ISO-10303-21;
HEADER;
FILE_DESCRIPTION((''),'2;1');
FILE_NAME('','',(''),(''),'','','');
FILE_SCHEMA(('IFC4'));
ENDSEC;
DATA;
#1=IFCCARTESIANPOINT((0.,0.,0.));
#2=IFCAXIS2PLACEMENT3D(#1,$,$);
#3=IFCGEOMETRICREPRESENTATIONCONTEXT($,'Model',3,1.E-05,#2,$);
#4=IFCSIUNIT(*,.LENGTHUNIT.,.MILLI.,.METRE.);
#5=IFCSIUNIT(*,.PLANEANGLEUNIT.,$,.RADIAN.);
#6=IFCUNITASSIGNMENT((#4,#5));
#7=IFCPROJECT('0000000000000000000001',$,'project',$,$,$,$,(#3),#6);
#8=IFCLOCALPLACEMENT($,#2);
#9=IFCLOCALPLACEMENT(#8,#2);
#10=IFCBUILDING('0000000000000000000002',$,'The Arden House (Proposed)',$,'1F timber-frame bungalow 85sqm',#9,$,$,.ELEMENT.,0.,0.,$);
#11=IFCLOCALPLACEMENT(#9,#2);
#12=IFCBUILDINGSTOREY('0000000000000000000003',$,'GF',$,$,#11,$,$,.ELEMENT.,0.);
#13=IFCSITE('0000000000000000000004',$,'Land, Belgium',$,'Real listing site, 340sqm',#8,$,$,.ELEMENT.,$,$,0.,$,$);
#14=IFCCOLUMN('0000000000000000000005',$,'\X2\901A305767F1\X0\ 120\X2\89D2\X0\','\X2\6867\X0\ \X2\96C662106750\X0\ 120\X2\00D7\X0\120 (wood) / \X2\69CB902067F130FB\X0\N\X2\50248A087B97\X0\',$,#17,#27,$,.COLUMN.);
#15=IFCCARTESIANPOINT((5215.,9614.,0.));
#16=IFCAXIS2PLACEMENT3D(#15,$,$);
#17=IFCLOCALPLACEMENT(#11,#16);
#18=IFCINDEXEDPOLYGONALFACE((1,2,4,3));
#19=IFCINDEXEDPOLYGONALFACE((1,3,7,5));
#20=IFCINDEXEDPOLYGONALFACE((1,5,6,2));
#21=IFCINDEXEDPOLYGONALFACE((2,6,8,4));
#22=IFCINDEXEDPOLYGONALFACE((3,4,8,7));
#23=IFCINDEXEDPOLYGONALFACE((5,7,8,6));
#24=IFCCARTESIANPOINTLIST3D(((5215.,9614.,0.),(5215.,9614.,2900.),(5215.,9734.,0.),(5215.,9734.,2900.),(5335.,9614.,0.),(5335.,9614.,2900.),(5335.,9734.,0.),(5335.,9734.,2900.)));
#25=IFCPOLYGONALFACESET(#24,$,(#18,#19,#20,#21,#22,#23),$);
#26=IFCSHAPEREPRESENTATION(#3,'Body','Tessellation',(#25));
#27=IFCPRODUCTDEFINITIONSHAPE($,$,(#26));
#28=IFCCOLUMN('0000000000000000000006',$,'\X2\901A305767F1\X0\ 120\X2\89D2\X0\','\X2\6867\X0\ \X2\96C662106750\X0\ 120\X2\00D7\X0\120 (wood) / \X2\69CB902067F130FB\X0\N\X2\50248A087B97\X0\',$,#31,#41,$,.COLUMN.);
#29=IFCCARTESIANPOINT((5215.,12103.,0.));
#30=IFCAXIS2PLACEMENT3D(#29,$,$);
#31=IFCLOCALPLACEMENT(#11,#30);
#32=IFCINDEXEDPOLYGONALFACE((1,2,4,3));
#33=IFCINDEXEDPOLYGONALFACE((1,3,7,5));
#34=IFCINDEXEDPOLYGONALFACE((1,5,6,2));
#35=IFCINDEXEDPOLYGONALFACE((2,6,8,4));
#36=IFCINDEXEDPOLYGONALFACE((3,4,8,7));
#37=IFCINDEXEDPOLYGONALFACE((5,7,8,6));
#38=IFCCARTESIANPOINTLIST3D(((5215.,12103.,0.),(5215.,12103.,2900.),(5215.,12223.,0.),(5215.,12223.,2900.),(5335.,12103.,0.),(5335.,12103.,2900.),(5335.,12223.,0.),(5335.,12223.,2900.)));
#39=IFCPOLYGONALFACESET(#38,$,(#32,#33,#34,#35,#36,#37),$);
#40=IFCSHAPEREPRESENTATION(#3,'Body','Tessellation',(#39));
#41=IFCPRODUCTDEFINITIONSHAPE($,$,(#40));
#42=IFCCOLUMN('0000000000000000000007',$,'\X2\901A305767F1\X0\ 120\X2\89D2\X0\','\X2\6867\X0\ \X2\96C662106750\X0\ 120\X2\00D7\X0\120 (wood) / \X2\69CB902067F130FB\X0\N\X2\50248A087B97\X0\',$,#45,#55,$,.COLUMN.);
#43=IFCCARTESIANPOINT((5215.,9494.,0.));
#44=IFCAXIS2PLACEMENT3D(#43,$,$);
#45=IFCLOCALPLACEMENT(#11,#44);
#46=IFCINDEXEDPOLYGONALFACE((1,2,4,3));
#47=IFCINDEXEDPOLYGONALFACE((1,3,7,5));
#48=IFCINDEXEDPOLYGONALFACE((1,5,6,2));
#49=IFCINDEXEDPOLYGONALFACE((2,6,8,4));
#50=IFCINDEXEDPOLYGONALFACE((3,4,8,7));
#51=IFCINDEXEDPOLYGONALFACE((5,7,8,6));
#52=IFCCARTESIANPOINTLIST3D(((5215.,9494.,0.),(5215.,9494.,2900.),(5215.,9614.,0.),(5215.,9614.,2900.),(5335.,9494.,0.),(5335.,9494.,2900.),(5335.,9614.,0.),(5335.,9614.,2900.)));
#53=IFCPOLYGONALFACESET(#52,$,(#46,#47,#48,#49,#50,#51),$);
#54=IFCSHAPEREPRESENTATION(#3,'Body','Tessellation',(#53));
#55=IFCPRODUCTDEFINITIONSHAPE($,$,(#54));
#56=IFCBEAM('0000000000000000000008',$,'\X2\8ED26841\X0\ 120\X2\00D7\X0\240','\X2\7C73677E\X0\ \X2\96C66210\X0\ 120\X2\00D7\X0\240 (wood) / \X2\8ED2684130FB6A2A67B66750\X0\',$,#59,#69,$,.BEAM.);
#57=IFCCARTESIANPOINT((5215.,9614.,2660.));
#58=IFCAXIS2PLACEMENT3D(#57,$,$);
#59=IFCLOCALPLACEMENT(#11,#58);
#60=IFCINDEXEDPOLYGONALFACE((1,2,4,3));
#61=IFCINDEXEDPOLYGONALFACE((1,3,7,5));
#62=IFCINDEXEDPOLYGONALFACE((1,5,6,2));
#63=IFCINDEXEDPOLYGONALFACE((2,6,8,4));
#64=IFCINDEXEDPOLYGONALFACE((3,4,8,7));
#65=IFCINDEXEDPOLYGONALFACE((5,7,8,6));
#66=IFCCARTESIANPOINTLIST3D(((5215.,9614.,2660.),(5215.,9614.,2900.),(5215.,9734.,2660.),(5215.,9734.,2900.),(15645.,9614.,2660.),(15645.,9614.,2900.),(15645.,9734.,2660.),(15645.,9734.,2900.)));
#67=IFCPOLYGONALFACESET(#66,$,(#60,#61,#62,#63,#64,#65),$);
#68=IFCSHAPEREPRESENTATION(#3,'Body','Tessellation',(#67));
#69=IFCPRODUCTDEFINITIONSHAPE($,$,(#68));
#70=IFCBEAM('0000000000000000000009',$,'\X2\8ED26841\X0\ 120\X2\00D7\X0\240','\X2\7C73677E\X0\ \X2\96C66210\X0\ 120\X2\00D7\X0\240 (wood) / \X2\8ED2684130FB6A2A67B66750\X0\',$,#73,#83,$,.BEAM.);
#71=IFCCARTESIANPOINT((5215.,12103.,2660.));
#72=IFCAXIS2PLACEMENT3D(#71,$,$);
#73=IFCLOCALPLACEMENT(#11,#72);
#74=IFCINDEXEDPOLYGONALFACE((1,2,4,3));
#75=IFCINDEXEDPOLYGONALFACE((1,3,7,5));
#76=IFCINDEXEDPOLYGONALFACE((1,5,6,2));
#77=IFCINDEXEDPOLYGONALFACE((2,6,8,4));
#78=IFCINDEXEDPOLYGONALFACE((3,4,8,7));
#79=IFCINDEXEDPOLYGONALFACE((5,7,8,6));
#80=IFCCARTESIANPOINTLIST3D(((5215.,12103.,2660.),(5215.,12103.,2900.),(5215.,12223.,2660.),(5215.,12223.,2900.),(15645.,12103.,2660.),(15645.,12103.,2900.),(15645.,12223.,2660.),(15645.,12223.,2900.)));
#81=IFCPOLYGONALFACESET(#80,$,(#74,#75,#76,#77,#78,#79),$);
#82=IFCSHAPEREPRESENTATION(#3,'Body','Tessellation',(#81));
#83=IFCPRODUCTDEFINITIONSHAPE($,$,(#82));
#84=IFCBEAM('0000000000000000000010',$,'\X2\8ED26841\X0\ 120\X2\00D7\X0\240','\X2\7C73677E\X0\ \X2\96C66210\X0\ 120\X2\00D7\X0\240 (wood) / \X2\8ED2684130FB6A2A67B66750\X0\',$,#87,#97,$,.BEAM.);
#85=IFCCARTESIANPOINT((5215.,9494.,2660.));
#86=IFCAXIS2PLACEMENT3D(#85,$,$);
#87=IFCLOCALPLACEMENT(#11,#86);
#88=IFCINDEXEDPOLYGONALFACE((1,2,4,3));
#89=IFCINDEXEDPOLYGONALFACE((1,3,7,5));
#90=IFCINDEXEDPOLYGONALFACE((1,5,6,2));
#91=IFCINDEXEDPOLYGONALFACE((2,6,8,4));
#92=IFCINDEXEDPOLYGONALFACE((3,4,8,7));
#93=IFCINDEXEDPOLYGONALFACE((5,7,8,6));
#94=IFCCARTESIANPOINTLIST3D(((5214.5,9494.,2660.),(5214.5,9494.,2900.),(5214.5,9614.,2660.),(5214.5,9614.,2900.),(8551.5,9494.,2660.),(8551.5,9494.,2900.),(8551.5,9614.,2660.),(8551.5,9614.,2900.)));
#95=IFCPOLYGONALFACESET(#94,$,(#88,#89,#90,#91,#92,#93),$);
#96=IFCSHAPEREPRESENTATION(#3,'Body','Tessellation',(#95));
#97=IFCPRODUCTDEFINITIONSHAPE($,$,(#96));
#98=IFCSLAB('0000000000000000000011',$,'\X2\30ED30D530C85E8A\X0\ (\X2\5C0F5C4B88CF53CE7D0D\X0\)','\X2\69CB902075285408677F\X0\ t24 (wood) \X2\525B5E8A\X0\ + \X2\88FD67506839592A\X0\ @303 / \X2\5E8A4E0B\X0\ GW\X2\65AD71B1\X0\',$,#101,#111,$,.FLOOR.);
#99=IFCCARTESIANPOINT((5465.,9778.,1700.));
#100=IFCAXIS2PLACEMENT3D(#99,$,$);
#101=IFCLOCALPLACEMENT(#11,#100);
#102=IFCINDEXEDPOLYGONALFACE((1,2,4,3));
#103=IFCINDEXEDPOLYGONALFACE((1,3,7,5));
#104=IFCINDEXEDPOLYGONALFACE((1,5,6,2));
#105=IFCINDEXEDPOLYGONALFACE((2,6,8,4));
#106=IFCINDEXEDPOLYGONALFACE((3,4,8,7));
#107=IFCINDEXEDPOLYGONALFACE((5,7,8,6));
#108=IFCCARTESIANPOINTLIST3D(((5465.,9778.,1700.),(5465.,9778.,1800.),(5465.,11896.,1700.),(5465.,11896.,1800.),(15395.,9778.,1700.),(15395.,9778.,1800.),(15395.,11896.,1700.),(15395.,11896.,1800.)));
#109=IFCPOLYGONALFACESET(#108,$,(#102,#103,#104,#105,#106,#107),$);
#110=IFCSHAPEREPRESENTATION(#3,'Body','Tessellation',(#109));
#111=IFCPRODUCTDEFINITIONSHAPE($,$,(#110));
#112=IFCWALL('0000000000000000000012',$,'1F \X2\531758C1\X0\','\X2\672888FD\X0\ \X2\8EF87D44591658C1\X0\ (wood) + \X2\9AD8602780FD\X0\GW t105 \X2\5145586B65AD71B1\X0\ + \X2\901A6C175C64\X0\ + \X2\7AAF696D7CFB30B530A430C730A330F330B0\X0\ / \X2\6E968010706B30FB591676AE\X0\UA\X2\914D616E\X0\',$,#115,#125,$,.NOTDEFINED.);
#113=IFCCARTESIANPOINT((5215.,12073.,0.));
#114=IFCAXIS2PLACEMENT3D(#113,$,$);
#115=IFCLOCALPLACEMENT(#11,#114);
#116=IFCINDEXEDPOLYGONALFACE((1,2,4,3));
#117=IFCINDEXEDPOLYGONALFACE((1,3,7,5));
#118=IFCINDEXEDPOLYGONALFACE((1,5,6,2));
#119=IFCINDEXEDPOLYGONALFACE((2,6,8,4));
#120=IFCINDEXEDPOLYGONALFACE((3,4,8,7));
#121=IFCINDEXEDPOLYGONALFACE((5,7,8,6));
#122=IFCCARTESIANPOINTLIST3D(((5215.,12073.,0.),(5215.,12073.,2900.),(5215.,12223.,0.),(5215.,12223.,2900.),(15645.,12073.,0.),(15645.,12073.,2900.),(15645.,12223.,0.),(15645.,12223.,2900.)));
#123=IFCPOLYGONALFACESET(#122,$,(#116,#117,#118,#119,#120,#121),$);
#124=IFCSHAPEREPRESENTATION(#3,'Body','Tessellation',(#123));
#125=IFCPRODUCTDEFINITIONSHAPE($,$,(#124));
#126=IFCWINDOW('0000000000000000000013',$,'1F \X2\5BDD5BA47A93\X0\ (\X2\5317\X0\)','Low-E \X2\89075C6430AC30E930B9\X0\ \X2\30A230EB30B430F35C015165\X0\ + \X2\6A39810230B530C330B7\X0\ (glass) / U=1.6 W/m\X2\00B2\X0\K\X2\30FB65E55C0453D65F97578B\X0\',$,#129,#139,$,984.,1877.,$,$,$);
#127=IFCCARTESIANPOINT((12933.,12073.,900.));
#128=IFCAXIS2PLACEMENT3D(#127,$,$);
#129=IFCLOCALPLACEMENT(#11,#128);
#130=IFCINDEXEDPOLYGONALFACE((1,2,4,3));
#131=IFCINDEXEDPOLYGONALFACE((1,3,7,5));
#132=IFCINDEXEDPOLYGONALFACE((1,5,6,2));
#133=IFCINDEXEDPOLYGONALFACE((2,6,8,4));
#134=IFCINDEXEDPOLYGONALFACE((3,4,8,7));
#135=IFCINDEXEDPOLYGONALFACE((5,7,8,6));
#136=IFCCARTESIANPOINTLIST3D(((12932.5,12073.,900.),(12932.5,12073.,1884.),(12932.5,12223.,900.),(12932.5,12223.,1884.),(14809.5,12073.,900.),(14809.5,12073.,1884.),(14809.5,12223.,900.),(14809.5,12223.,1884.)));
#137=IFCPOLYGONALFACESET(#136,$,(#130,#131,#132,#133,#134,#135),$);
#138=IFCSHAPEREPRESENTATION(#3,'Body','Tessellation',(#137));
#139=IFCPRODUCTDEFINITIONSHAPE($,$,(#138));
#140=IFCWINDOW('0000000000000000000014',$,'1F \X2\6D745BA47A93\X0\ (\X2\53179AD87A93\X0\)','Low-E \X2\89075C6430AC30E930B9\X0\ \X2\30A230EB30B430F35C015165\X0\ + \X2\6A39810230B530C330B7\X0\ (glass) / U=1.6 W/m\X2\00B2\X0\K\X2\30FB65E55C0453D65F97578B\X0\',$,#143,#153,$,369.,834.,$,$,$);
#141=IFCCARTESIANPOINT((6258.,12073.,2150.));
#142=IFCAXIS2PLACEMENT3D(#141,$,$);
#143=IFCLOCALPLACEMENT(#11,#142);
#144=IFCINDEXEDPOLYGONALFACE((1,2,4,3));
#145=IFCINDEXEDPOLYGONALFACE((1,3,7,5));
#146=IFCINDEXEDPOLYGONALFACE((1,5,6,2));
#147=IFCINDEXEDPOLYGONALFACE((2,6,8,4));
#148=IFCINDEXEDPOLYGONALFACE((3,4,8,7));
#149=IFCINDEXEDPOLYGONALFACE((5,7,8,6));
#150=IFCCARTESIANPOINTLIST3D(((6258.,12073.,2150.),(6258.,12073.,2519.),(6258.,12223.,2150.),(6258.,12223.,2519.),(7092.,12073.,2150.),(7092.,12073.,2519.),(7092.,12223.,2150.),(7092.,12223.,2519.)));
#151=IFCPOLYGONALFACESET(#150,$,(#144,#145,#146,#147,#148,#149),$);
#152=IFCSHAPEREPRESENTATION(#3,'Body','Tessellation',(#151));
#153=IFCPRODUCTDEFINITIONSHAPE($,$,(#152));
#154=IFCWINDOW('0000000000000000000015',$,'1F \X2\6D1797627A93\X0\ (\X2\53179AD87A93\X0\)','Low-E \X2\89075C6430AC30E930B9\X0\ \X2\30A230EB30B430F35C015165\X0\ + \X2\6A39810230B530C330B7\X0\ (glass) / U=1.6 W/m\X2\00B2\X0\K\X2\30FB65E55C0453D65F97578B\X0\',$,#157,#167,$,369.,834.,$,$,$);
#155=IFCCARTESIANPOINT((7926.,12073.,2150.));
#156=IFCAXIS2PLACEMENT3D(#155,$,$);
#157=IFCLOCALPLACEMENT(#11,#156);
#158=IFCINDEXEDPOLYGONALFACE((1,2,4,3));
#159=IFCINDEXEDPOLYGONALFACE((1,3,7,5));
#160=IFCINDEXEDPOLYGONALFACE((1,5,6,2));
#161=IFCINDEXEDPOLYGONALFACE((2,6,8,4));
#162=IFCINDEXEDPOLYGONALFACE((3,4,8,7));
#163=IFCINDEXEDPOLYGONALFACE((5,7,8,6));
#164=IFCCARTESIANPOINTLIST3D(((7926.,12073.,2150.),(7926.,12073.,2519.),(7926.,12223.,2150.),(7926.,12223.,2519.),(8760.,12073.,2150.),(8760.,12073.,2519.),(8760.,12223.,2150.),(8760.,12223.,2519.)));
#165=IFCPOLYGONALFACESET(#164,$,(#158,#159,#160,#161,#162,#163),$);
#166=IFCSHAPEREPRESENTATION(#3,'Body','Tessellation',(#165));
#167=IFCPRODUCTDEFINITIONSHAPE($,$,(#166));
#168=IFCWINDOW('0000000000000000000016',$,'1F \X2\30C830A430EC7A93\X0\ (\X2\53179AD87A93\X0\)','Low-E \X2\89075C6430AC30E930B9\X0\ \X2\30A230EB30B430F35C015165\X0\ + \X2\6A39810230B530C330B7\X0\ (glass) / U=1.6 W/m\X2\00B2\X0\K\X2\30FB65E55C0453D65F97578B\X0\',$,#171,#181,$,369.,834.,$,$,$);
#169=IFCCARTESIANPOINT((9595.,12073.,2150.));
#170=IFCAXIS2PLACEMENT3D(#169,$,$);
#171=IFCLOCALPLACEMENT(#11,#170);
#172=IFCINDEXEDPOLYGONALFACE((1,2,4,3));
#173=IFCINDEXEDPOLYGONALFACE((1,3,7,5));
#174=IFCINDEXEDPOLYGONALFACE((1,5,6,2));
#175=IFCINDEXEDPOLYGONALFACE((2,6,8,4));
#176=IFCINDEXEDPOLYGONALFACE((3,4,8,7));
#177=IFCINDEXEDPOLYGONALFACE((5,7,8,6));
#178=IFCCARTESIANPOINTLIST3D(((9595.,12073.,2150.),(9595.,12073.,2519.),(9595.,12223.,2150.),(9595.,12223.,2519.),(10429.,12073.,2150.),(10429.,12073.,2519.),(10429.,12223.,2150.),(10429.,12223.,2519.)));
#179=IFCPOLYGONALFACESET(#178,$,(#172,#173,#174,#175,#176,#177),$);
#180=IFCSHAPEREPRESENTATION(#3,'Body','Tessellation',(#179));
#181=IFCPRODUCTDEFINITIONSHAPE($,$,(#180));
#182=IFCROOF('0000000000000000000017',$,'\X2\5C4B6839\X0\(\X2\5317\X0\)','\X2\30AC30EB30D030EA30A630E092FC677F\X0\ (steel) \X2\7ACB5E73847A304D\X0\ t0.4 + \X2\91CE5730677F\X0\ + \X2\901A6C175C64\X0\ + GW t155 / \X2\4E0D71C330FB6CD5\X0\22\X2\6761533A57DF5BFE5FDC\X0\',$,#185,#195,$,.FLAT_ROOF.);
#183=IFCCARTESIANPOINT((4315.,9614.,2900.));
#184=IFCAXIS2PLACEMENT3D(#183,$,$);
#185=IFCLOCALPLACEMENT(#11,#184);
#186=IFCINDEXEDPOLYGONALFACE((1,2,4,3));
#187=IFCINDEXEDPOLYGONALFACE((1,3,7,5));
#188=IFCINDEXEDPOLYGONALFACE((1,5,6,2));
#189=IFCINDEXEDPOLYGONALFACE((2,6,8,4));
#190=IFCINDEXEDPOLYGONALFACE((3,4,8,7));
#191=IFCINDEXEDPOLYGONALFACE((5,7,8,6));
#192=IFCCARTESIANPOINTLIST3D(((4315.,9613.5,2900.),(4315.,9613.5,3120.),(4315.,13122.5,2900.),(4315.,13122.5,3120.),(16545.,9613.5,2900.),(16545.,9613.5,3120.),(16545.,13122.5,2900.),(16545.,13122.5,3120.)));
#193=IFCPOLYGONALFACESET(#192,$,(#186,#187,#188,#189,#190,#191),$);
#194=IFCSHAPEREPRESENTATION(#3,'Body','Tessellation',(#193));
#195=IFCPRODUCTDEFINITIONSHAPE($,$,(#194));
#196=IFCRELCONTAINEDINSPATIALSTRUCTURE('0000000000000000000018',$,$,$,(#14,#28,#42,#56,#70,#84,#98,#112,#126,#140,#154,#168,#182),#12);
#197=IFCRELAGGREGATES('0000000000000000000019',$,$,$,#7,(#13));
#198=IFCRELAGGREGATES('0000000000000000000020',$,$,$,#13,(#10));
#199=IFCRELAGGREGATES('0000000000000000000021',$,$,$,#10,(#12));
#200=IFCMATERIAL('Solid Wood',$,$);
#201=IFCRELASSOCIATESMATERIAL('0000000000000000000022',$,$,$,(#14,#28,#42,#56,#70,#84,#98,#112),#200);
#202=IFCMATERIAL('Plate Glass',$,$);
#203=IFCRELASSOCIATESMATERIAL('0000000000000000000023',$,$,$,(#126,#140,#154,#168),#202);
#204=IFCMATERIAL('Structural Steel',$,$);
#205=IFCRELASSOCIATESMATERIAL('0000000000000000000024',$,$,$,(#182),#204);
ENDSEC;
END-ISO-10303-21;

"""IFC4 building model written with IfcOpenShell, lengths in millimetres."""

from ifc_helpers import new_model, si_unit, frame, frame_2d, origin, place, context, project, spatial, rectangle, extrude, material, element, fill, save


model = new_model("IFC4")

# Units and contexts
model_context = context("Model", 3, precision=1e-05, world=origin())
ifc_project = project(units=[si_unit("LENGTHUNIT", "METRE", prefix="MILLI"), si_unit("PLANEANGLEUNIT", "RADIAN")], contexts=[model_context])

# Site, building, storey
site_placement = place(None, origin())
site = spatial("IfcSite", under=ifc_project, at=site_placement, Name="Land, Belgium", ObjectType="Real listing site, 340sqm", CompositionType="ELEMENT", RefElevation=0.0)
building_placement = place(site_placement, origin())
building = spatial("IfcBuilding", under=site, at=building_placement, Name="The Arden House (Proposed)", ObjectType="1F timber-frame bungalow 85sqm", CompositionType="ELEMENT", ElevationOfRefHeight=0.0, ElevationOfTerrain=0.0)
storey_placement = place(building_placement, origin())
storey = spatial("IfcBuildingStorey", under=building, at=storey_placement, Name="GF", CompositionType="ELEMENT", Elevation=0.0)

# Columns
ifc_material_1 = material(Name="Solid Wood")
column_1_placement = place(storey_placement, frame((5215.0, 9614.0, 0.0)))
element("IfcColumn", 1, at=column_1_placement, inside=storey, material=ifc_material_1, Name="通し柱 120角", Description="桧 集成材 120×120 (wood) / 構造柱・N値計算", PredefinedType="COLUMN", context=model_context, shape_type="SweptSolid", body=[
    extrude(rectangle(XDim=120.0, YDim=120.0, at=frame_2d((60.0, 60.0))), frame((5215.0, 9614.0, 0.0)), (0.0, 0.0, 1.0), 2900.0),
])
column_2_placement = place(storey_placement, frame((5215.0, 12103.0, 0.0)))
element("IfcColumn", 2, at=column_2_placement, inside=storey, material=ifc_material_1, Name="通し柱 120角", Description="桧 集成材 120×120 (wood) / 構造柱・N値計算", PredefinedType="COLUMN", context=model_context, shape_type="SweptSolid", body=[
    extrude(rectangle(XDim=120.0, YDim=120.0, at=frame_2d((60.0, 60.0))), frame((5215.0, 12103.0, 0.0)), (0.0, 0.0, 1.0), 2900.0),
])
column_3_placement = place(storey_placement, frame((5215.0, 9494.0, 0.0)))
element("IfcColumn", 3, at=column_3_placement, inside=storey, material=ifc_material_1, Name="通し柱 120角", Description="桧 集成材 120×120 (wood) / 構造柱・N値計算", PredefinedType="COLUMN", context=model_context, shape_type="SweptSolid", body=[
    extrude(rectangle(XDim=120.0, YDim=120.0, at=frame_2d((60.0, 60.0))), frame((5215.0, 9494.0, 0.0)), (0.0, 0.0, 1.0), 2900.0),
])

# Beams
beam_1_placement = place(storey_placement, frame((5215.0, 9614.0, 2660.0)))
element("IfcBeam", 4, at=beam_1_placement, inside=storey, material=ifc_material_1, Name="軒桁 120×240", Description="米松 集成 120×240 (wood) / 軒桁・横架材", PredefinedType="BEAM", context=model_context, shape_type="SweptSolid", body=[
    extrude(rectangle(XDim=10430.0, YDim=120.0, at=frame_2d((5215.0, 60.0))), frame((5215.0, 9614.0, 2660.0)), (0.0, 0.0, 1.0), 240.0),
])
beam_2_placement = place(storey_placement, frame((5215.0, 12103.0, 2660.0)))
element("IfcBeam", 5, at=beam_2_placement, inside=storey, material=ifc_material_1, Name="軒桁 120×240", Description="米松 集成 120×240 (wood) / 軒桁・横架材", PredefinedType="BEAM", context=model_context, shape_type="SweptSolid", body=[
    extrude(rectangle(XDim=10430.0, YDim=120.0, at=frame_2d((5215.0, 60.0))), frame((5215.0, 12103.0, 2660.0)), (0.0, 0.0, 1.0), 240.0),
])
beam_3_placement = place(storey_placement, frame((5215.0, 9494.0, 2660.0)))
element("IfcBeam", 6, at=beam_3_placement, inside=storey, material=ifc_material_1, Name="軒桁 120×240", Description="米松 集成 120×240 (wood) / 軒桁・横架材", PredefinedType="BEAM", context=model_context, shape_type="SweptSolid", body=[
    extrude(rectangle(XDim=3337.0, YDim=120.0, at=frame_2d((1668.0, 60.0))), frame((5215.0, 9494.0, 2660.0)), (0.0, 0.0, 1.0), 240.0),
])

# Slab
slab_1_placement = place(storey_placement, frame((5465.0, 9778.0, 1700.0)))
element("IfcSlab", 7, at=slab_1_placement, inside=storey, material=ifc_material_1, Name="ロフト床 (小屋裏収納)", Description="構造用合板 t24 (wood) 剛床 + 製材根太 @303 / 床下 GW断熱", PredefinedType="FLOOR", context=model_context, shape_type="SweptSolid", body=[
    extrude(rectangle(XDim=9930.0, YDim=2118.0, at=frame_2d((4965.0, 1059.0))), frame((5465.0, 9778.0, 1700.0)), (0.0, 0.0, 1.0), 100.0),
])

# Wall, openings, windows
wall_1_placement = place(storey_placement, frame((5215.0, 12073.0, 0.0)))
wall_1 = element("IfcWall", 8, at=wall_1_placement, inside=storey, material=ifc_material_1, Name="1F 北壁", Description="木製 軸組外壁 (wood) + 高性能GW t105 充填断熱 + 通気層 + 窯業系サイディング / 準耐火・外皮UA配慮", PredefinedType="NOTDEFINED", context=model_context, shape_type="SweptSolid", body=[
    extrude(rectangle(XDim=10430.0, YDim=150.0, at=frame_2d((5215.0, 75.0))), frame((5215.0, 12073.0, 0.0)), (0.0, 0.0, 1.0), 2900.0),
])
opening_1_placement = place(storey_placement, frame((12933.0, 12073.0, 900.0)))
opening_1 = element("IfcOpeningElement", 9, at=opening_1_placement, cuts=wall_1, PredefinedType="NOTDEFINED", context=model_context, shape_type="SweptSolid", body=[
    extrude(rectangle(XDim=1877.0, YDim=150.0, at=frame_2d((938.0, 75.0))), frame((12933.0, 12073.0, 900.0)), (0.0, 0.0, 1.0), 984.0),
])
opening_2_placement = place(storey_placement, frame((6258.0, 12073.0, 2150.0)))
opening_2 = element("IfcOpeningElement", 10, at=opening_2_placement, cuts=wall_1, PredefinedType="NOTDEFINED", context=model_context, shape_type="SweptSolid", body=[
    extrude(rectangle(XDim=834.0, YDim=150.0, at=frame_2d((417.0, 75.0))), frame((6258.0, 12073.0, 2150.0)), (0.0, 0.0, 1.0), 369.0),
])
opening_3_placement = place(storey_placement, frame((7926.0, 12073.0, 2150.0)))
opening_3 = element("IfcOpeningElement", 11, at=opening_3_placement, cuts=wall_1, PredefinedType="NOTDEFINED", context=model_context, shape_type="SweptSolid", body=[
    extrude(rectangle(XDim=834.0, YDim=150.0, at=frame_2d((417.0, 75.0))), frame((7926.0, 12073.0, 2150.0)), (0.0, 0.0, 1.0), 369.0),
])
opening_4_placement = place(storey_placement, frame((9595.0, 12073.0, 2150.0)))
opening_4 = element("IfcOpeningElement", 12, at=opening_4_placement, cuts=wall_1, PredefinedType="NOTDEFINED", context=model_context, shape_type="SweptSolid", body=[
    extrude(rectangle(XDim=834.0, YDim=150.0, at=frame_2d((417.0, 75.0))), frame((9595.0, 12073.0, 2150.0)), (0.0, 0.0, 1.0), 369.0),
])
ifc_material_2 = material(Name="Plate Glass")
window_1_placement = place(storey_placement, frame((12933.0, 12073.0, 900.0)))
window_1 = element("IfcWindow", 13, at=window_1_placement, inside=storey, material=ifc_material_2, Name="1F 寝室窓 (北)", Description="Low-E 複層ガラス アルゴン封入 + 樹脂サッシ (glass) / U=1.6 W/m²K・日射取得型", OverallHeight=984.0, OverallWidth=1877.0, context=model_context, shape_type="SweptSolid", body=[
    extrude(rectangle(XDim=1877.0, YDim=150.0, at=frame_2d((938.0, 75.0))), frame((12933.0, 12073.0, 900.0)), (0.0, 0.0, 1.0), 984.0),
])
fill(opening_1, window_1)
window_2_placement = place(storey_placement, frame((6258.0, 12073.0, 2150.0)))
window_2 = element("IfcWindow", 14, at=window_2_placement, inside=storey, material=ifc_material_2, Name="1F 浴室窓 (北高窓)", Description="Low-E 複層ガラス アルゴン封入 + 樹脂サッシ (glass) / U=1.6 W/m²K・日射取得型", OverallHeight=369.0, OverallWidth=834.0, context=model_context, shape_type="SweptSolid", body=[
    extrude(rectangle(XDim=834.0, YDim=150.0, at=frame_2d((417.0, 75.0))), frame((6258.0, 12073.0, 2150.0)), (0.0, 0.0, 1.0), 369.0),
])
fill(opening_2, window_2)
window_3_placement = place(storey_placement, frame((7926.0, 12073.0, 2150.0)))
window_3 = element("IfcWindow", 15, at=window_3_placement, inside=storey, material=ifc_material_2, Name="1F 洗面窓 (北高窓)", Description="Low-E 複層ガラス アルゴン封入 + 樹脂サッシ (glass) / U=1.6 W/m²K・日射取得型", OverallHeight=369.0, OverallWidth=834.0, context=model_context, shape_type="SweptSolid", body=[
    extrude(rectangle(XDim=834.0, YDim=150.0, at=frame_2d((417.0, 75.0))), frame((7926.0, 12073.0, 2150.0)), (0.0, 0.0, 1.0), 369.0),
])
fill(opening_3, window_3)
window_4_placement = place(storey_placement, frame((9595.0, 12073.0, 2150.0)))
window_4 = element("IfcWindow", 16, at=window_4_placement, inside=storey, material=ifc_material_2, Name="1F トイレ窓 (北高窓)", Description="Low-E 複層ガラス アルゴン封入 + 樹脂サッシ (glass) / U=1.6 W/m²K・日射取得型", OverallHeight=369.0, OverallWidth=834.0, context=model_context, shape_type="SweptSolid", body=[
    extrude(rectangle(XDim=834.0, YDim=150.0, at=frame_2d((417.0, 75.0))), frame((9595.0, 12073.0, 2150.0)), (0.0, 0.0, 1.0), 369.0),
])
fill(opening_4, window_4)

# Roof
ifc_material_3 = material(Name="Structural Steel")
roof_placement = place(storey_placement, frame((4315.0, 9614.0, 2900.0)))
element("IfcRoof", 17, at=roof_placement, inside=storey, material=ifc_material_3, Name="屋根(北)", Description="ガルバリウム鋼板 (steel) 立平葺き t0.4 + 野地板 + 通気層 + GW t155 / 不燃・法22条区域対応", PredefinedType="FLAT_ROOF", context=model_context, shape_type="SweptSolid", body=[
    extrude(rectangle(XDim=12230.0, YDim=3509.0, at=frame_2d((6115.0, 1754.0))), frame((4315.0, 9614.0, 2900.0)), (0.0, 0.0, 1.0), 220.0),
])

save(model, "model.ifc")
